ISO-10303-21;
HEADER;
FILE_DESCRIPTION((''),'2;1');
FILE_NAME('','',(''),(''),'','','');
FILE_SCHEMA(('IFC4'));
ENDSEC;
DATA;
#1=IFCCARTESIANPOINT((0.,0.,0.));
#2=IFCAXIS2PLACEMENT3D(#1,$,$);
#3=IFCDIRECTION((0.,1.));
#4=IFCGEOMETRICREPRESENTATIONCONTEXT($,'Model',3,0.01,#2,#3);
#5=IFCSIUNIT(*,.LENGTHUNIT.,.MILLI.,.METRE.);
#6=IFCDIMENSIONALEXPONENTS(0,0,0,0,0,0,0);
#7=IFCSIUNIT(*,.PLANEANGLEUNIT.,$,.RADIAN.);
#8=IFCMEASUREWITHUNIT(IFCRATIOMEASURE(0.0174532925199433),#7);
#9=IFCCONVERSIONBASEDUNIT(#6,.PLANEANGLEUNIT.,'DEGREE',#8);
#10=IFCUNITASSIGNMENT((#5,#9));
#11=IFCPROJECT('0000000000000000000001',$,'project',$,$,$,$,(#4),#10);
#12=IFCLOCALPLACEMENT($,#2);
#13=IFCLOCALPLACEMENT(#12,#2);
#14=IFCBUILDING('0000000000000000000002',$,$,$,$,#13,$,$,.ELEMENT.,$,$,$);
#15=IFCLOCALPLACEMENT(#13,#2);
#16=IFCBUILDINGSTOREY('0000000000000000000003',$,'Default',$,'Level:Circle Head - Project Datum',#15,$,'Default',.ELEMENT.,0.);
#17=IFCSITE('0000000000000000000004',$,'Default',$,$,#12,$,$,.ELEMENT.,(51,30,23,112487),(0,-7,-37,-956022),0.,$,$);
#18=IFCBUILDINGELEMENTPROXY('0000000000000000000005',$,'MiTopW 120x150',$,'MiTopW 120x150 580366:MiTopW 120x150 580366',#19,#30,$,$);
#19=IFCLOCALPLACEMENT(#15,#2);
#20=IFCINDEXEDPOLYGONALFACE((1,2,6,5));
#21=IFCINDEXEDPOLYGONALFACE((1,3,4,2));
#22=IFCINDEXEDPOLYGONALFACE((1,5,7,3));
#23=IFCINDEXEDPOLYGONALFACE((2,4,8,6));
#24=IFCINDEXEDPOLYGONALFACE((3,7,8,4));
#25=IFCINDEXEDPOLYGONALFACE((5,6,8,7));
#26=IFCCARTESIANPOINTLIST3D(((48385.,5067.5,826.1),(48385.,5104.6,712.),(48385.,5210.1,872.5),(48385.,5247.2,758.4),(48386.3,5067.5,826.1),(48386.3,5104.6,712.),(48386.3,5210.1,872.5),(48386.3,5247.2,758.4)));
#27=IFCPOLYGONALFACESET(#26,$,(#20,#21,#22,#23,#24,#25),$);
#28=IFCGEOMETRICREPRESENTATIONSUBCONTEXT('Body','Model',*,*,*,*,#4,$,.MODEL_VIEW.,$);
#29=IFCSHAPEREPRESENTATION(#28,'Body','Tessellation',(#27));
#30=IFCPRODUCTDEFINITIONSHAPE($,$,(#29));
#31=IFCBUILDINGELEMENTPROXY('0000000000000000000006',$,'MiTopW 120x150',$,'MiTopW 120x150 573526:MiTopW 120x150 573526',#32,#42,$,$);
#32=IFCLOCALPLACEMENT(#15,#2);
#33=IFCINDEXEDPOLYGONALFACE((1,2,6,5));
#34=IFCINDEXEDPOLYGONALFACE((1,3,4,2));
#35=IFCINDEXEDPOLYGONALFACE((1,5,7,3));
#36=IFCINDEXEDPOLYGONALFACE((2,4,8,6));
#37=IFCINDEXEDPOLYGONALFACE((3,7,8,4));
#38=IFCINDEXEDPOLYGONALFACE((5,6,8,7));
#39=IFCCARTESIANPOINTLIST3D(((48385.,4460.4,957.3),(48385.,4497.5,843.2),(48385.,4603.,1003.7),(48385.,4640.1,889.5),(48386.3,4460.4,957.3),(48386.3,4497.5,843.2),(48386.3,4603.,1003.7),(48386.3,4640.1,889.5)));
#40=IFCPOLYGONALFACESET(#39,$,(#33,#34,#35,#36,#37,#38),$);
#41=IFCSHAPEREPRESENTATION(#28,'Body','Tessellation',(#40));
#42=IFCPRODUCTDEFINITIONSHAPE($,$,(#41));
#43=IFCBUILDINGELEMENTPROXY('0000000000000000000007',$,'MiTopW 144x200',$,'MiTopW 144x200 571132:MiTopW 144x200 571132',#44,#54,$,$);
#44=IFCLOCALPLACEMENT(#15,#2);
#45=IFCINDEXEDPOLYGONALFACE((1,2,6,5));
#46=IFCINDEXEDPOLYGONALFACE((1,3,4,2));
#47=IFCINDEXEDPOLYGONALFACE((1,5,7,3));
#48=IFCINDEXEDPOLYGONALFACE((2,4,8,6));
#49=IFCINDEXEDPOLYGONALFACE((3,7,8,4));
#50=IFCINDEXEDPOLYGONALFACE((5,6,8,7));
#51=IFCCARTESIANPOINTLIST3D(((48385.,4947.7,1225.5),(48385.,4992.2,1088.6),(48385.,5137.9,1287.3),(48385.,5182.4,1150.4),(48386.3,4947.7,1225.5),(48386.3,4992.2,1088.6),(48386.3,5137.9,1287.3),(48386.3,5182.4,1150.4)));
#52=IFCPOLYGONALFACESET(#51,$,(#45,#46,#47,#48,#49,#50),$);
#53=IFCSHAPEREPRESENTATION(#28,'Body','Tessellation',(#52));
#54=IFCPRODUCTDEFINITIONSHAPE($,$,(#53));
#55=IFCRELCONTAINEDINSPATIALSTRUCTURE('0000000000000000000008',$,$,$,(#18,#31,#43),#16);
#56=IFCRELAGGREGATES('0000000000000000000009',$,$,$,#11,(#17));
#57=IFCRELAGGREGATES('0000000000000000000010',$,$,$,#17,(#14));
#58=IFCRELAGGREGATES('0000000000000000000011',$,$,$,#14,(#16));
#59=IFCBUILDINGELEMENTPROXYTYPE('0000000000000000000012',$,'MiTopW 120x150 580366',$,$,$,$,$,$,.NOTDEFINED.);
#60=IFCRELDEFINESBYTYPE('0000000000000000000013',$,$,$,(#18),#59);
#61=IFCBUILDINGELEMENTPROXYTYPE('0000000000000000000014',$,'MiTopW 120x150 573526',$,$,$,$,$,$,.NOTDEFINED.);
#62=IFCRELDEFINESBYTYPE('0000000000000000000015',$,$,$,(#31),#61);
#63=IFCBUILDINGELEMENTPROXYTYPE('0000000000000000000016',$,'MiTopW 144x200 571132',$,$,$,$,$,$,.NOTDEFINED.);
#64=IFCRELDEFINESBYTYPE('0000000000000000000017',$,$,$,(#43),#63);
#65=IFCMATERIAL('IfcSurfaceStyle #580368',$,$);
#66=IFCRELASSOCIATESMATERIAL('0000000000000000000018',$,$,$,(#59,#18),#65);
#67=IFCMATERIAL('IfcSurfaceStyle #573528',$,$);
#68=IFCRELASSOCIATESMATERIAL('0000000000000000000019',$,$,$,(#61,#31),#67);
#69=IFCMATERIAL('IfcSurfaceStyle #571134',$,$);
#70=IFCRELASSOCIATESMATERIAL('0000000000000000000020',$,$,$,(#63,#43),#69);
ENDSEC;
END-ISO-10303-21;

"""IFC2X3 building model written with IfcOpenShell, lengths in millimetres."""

from ifc_helpers import new_model, entity, si_unit, converted_unit, direction, frame, origin, place, context, subcontext, project, spatial, polyline, outline, extrude, source, transform, mapped, material, type_object, type_shapes, element, save


model = new_model("IFC2X3")

# Units and contexts
model_context = context("Model", 3, precision=0.01, world=origin(), true_north=direction((0.0, 1.0)))
body_context = subcontext(model_context, "Body", "Model", "MODEL_VIEW")
ifc_project = project(units=[si_unit("LENGTHUNIT", "METRE", prefix="MILLI"), converted_unit("PLANEANGLEUNIT", "DEGREE", entity("IfcRatioMeasure", 0.0174532925199433), si_unit("PLANEANGLEUNIT", "RADIAN"), dimensions=[0, 0, 0, 0, 0, 0, 0])], contexts=[model_context])

# Site, building, storey
site_placement = place(None, origin())
site = spatial("IfcSite", under=ifc_project, at=site_placement, Name="Default", CompositionType="ELEMENT", RefLatitude=(51, 30, 23, 112487), RefLongitude=(0, -7, -37, -956022), RefElevation=0.0)
building_placement = place(site_placement, origin())
building = spatial("IfcBuilding", under=site, at=building_placement, CompositionType="ELEMENT")
storey_placement = place(building_placement, origin())
storey = spatial("IfcBuildingStorey", under=building, at=storey_placement, Name="Default", ObjectType="Level:Circle Head - Project Datum", LongName="Default", CompositionType="ELEMENT", Elevation=0.0)

# Building element proxies
ifc_material_1 = material(Name="IfcSurfaceStyle #580368")
building_element_proxy_type_1 = type_object("IfcBuildingElementProxyType", Name="MiTopW 120x150 580366", PredefinedType="NOTDEFINED", material=ifc_material_1)
shared_shape_1 = source(origin(), body_context, "Body", "SweptSolid", [
    extrude(outline(polyline([(-75.0, -60.0), (75.0, -60.0), (75.0, 60.0), (-75.0, 60.0), (-75.0, -60.0)])), frame((75.0, 60.0, 0.0), z_axis=(0.0, 0.0, 1.0), x_axis=(-1.0, 0.0, 0.0)), (0.0, 0.0, 1.0), 1.3),
])
type_shapes(building_element_proxy_type_1, [shared_shape_1])
proxy_1_placement = place(building_placement, frame((48386.3, 5067.5, 826.1), z_axis=(-1.0, 0.0, 0.0), x_axis=(0.0, 0.951057, 0.309017)))
element("IfcBuildingElementProxy", 1, at=proxy_1_placement, inside=storey, type_object=building_element_proxy_type_1, material=ifc_material_1, Name="MiTopW 120x150", ObjectType="MiTopW 120x150 580366:MiTopW 120x150 580366", context=body_context, shape_type="MappedRepresentation", body=[
    mapped(shared_shape_1, transform((0.0, 0.0, 0.0), scale=1.0)),
])
ifc_material_2 = material(Name="IfcSurfaceStyle #573528")
building_element_proxy_type_2 = type_object("IfcBuildingElementProxyType", Name="MiTopW 120x150 573526", PredefinedType="NOTDEFINED", material=ifc_material_2)
shared_shape_2 = source(origin(), body_context, "Body", "SweptSolid", [
    extrude(outline(polyline([(-75.0, -60.0), (75.0, -60.0), (75.0, 60.0), (-75.0, 60.0), (-75.0, -60.0)])), frame((75.0, 60.0, 0.0), z_axis=(0.0, 0.0, 1.0), x_axis=(-1.0, 0.0, 0.0)), (0.0, 0.0, 1.0), 1.3),
])
type_shapes(building_element_proxy_type_2, [shared_shape_2])
proxy_2_placement = place(building_placement, frame((48386.3, 4460.4, 957.3), z_axis=(-1.0, 0.0, 0.0), x_axis=(0.0, 0.951057, 0.309017)))
element("IfcBuildingElementProxy", 2, at=proxy_2_placement, inside=storey, type_object=building_element_proxy_type_2, material=ifc_material_2, Name="MiTopW 120x150", ObjectType="MiTopW 120x150 573526:MiTopW 120x150 573526", context=body_context, shape_type="MappedRepresentation", body=[
    mapped(shared_shape_2, transform((0.0, 0.0, 0.0), scale=1.0)),
])
ifc_material_3 = material(Name="IfcSurfaceStyle #571134")
building_element_proxy_type_3 = type_object("IfcBuildingElementProxyType", Name="MiTopW 144x200 571132", PredefinedType="NOTDEFINED", material=ifc_material_3)
shared_shape_3 = source(origin(), body_context, "Body", "SweptSolid", [
    extrude(outline(polyline([(-100.0, -72.0), (100.0, -72.0), (100.0, 72.0), (-100.0, 72.0), (-100.0, -72.0)])), frame((100.0, 72.0, 0.0), z_axis=(0.0, 0.0, 1.0), x_axis=(-1.0, 0.0, 0.0)), (0.0, 0.0, 1.0), 1.3),
])
type_shapes(building_element_proxy_type_3, [shared_shape_3])
proxy_3_placement = place(building_placement, frame((48386.3, 4947.7, 1225.5), z_axis=(-1.0, 0.0, 0.0), x_axis=(0.0, 0.951057, 0.309017)))
element("IfcBuildingElementProxy", 3, at=proxy_3_placement, inside=storey, type_object=building_element_proxy_type_3, material=ifc_material_3, Name="MiTopW 144x200", ObjectType="MiTopW 144x200 571132:MiTopW 144x200 571132", context=body_context, shape_type="MappedRepresentation", body=[
    mapped(shared_shape_3, transform((0.0, 0.0, 0.0), scale=1.0)),
])

save(model, "model.ifc")
